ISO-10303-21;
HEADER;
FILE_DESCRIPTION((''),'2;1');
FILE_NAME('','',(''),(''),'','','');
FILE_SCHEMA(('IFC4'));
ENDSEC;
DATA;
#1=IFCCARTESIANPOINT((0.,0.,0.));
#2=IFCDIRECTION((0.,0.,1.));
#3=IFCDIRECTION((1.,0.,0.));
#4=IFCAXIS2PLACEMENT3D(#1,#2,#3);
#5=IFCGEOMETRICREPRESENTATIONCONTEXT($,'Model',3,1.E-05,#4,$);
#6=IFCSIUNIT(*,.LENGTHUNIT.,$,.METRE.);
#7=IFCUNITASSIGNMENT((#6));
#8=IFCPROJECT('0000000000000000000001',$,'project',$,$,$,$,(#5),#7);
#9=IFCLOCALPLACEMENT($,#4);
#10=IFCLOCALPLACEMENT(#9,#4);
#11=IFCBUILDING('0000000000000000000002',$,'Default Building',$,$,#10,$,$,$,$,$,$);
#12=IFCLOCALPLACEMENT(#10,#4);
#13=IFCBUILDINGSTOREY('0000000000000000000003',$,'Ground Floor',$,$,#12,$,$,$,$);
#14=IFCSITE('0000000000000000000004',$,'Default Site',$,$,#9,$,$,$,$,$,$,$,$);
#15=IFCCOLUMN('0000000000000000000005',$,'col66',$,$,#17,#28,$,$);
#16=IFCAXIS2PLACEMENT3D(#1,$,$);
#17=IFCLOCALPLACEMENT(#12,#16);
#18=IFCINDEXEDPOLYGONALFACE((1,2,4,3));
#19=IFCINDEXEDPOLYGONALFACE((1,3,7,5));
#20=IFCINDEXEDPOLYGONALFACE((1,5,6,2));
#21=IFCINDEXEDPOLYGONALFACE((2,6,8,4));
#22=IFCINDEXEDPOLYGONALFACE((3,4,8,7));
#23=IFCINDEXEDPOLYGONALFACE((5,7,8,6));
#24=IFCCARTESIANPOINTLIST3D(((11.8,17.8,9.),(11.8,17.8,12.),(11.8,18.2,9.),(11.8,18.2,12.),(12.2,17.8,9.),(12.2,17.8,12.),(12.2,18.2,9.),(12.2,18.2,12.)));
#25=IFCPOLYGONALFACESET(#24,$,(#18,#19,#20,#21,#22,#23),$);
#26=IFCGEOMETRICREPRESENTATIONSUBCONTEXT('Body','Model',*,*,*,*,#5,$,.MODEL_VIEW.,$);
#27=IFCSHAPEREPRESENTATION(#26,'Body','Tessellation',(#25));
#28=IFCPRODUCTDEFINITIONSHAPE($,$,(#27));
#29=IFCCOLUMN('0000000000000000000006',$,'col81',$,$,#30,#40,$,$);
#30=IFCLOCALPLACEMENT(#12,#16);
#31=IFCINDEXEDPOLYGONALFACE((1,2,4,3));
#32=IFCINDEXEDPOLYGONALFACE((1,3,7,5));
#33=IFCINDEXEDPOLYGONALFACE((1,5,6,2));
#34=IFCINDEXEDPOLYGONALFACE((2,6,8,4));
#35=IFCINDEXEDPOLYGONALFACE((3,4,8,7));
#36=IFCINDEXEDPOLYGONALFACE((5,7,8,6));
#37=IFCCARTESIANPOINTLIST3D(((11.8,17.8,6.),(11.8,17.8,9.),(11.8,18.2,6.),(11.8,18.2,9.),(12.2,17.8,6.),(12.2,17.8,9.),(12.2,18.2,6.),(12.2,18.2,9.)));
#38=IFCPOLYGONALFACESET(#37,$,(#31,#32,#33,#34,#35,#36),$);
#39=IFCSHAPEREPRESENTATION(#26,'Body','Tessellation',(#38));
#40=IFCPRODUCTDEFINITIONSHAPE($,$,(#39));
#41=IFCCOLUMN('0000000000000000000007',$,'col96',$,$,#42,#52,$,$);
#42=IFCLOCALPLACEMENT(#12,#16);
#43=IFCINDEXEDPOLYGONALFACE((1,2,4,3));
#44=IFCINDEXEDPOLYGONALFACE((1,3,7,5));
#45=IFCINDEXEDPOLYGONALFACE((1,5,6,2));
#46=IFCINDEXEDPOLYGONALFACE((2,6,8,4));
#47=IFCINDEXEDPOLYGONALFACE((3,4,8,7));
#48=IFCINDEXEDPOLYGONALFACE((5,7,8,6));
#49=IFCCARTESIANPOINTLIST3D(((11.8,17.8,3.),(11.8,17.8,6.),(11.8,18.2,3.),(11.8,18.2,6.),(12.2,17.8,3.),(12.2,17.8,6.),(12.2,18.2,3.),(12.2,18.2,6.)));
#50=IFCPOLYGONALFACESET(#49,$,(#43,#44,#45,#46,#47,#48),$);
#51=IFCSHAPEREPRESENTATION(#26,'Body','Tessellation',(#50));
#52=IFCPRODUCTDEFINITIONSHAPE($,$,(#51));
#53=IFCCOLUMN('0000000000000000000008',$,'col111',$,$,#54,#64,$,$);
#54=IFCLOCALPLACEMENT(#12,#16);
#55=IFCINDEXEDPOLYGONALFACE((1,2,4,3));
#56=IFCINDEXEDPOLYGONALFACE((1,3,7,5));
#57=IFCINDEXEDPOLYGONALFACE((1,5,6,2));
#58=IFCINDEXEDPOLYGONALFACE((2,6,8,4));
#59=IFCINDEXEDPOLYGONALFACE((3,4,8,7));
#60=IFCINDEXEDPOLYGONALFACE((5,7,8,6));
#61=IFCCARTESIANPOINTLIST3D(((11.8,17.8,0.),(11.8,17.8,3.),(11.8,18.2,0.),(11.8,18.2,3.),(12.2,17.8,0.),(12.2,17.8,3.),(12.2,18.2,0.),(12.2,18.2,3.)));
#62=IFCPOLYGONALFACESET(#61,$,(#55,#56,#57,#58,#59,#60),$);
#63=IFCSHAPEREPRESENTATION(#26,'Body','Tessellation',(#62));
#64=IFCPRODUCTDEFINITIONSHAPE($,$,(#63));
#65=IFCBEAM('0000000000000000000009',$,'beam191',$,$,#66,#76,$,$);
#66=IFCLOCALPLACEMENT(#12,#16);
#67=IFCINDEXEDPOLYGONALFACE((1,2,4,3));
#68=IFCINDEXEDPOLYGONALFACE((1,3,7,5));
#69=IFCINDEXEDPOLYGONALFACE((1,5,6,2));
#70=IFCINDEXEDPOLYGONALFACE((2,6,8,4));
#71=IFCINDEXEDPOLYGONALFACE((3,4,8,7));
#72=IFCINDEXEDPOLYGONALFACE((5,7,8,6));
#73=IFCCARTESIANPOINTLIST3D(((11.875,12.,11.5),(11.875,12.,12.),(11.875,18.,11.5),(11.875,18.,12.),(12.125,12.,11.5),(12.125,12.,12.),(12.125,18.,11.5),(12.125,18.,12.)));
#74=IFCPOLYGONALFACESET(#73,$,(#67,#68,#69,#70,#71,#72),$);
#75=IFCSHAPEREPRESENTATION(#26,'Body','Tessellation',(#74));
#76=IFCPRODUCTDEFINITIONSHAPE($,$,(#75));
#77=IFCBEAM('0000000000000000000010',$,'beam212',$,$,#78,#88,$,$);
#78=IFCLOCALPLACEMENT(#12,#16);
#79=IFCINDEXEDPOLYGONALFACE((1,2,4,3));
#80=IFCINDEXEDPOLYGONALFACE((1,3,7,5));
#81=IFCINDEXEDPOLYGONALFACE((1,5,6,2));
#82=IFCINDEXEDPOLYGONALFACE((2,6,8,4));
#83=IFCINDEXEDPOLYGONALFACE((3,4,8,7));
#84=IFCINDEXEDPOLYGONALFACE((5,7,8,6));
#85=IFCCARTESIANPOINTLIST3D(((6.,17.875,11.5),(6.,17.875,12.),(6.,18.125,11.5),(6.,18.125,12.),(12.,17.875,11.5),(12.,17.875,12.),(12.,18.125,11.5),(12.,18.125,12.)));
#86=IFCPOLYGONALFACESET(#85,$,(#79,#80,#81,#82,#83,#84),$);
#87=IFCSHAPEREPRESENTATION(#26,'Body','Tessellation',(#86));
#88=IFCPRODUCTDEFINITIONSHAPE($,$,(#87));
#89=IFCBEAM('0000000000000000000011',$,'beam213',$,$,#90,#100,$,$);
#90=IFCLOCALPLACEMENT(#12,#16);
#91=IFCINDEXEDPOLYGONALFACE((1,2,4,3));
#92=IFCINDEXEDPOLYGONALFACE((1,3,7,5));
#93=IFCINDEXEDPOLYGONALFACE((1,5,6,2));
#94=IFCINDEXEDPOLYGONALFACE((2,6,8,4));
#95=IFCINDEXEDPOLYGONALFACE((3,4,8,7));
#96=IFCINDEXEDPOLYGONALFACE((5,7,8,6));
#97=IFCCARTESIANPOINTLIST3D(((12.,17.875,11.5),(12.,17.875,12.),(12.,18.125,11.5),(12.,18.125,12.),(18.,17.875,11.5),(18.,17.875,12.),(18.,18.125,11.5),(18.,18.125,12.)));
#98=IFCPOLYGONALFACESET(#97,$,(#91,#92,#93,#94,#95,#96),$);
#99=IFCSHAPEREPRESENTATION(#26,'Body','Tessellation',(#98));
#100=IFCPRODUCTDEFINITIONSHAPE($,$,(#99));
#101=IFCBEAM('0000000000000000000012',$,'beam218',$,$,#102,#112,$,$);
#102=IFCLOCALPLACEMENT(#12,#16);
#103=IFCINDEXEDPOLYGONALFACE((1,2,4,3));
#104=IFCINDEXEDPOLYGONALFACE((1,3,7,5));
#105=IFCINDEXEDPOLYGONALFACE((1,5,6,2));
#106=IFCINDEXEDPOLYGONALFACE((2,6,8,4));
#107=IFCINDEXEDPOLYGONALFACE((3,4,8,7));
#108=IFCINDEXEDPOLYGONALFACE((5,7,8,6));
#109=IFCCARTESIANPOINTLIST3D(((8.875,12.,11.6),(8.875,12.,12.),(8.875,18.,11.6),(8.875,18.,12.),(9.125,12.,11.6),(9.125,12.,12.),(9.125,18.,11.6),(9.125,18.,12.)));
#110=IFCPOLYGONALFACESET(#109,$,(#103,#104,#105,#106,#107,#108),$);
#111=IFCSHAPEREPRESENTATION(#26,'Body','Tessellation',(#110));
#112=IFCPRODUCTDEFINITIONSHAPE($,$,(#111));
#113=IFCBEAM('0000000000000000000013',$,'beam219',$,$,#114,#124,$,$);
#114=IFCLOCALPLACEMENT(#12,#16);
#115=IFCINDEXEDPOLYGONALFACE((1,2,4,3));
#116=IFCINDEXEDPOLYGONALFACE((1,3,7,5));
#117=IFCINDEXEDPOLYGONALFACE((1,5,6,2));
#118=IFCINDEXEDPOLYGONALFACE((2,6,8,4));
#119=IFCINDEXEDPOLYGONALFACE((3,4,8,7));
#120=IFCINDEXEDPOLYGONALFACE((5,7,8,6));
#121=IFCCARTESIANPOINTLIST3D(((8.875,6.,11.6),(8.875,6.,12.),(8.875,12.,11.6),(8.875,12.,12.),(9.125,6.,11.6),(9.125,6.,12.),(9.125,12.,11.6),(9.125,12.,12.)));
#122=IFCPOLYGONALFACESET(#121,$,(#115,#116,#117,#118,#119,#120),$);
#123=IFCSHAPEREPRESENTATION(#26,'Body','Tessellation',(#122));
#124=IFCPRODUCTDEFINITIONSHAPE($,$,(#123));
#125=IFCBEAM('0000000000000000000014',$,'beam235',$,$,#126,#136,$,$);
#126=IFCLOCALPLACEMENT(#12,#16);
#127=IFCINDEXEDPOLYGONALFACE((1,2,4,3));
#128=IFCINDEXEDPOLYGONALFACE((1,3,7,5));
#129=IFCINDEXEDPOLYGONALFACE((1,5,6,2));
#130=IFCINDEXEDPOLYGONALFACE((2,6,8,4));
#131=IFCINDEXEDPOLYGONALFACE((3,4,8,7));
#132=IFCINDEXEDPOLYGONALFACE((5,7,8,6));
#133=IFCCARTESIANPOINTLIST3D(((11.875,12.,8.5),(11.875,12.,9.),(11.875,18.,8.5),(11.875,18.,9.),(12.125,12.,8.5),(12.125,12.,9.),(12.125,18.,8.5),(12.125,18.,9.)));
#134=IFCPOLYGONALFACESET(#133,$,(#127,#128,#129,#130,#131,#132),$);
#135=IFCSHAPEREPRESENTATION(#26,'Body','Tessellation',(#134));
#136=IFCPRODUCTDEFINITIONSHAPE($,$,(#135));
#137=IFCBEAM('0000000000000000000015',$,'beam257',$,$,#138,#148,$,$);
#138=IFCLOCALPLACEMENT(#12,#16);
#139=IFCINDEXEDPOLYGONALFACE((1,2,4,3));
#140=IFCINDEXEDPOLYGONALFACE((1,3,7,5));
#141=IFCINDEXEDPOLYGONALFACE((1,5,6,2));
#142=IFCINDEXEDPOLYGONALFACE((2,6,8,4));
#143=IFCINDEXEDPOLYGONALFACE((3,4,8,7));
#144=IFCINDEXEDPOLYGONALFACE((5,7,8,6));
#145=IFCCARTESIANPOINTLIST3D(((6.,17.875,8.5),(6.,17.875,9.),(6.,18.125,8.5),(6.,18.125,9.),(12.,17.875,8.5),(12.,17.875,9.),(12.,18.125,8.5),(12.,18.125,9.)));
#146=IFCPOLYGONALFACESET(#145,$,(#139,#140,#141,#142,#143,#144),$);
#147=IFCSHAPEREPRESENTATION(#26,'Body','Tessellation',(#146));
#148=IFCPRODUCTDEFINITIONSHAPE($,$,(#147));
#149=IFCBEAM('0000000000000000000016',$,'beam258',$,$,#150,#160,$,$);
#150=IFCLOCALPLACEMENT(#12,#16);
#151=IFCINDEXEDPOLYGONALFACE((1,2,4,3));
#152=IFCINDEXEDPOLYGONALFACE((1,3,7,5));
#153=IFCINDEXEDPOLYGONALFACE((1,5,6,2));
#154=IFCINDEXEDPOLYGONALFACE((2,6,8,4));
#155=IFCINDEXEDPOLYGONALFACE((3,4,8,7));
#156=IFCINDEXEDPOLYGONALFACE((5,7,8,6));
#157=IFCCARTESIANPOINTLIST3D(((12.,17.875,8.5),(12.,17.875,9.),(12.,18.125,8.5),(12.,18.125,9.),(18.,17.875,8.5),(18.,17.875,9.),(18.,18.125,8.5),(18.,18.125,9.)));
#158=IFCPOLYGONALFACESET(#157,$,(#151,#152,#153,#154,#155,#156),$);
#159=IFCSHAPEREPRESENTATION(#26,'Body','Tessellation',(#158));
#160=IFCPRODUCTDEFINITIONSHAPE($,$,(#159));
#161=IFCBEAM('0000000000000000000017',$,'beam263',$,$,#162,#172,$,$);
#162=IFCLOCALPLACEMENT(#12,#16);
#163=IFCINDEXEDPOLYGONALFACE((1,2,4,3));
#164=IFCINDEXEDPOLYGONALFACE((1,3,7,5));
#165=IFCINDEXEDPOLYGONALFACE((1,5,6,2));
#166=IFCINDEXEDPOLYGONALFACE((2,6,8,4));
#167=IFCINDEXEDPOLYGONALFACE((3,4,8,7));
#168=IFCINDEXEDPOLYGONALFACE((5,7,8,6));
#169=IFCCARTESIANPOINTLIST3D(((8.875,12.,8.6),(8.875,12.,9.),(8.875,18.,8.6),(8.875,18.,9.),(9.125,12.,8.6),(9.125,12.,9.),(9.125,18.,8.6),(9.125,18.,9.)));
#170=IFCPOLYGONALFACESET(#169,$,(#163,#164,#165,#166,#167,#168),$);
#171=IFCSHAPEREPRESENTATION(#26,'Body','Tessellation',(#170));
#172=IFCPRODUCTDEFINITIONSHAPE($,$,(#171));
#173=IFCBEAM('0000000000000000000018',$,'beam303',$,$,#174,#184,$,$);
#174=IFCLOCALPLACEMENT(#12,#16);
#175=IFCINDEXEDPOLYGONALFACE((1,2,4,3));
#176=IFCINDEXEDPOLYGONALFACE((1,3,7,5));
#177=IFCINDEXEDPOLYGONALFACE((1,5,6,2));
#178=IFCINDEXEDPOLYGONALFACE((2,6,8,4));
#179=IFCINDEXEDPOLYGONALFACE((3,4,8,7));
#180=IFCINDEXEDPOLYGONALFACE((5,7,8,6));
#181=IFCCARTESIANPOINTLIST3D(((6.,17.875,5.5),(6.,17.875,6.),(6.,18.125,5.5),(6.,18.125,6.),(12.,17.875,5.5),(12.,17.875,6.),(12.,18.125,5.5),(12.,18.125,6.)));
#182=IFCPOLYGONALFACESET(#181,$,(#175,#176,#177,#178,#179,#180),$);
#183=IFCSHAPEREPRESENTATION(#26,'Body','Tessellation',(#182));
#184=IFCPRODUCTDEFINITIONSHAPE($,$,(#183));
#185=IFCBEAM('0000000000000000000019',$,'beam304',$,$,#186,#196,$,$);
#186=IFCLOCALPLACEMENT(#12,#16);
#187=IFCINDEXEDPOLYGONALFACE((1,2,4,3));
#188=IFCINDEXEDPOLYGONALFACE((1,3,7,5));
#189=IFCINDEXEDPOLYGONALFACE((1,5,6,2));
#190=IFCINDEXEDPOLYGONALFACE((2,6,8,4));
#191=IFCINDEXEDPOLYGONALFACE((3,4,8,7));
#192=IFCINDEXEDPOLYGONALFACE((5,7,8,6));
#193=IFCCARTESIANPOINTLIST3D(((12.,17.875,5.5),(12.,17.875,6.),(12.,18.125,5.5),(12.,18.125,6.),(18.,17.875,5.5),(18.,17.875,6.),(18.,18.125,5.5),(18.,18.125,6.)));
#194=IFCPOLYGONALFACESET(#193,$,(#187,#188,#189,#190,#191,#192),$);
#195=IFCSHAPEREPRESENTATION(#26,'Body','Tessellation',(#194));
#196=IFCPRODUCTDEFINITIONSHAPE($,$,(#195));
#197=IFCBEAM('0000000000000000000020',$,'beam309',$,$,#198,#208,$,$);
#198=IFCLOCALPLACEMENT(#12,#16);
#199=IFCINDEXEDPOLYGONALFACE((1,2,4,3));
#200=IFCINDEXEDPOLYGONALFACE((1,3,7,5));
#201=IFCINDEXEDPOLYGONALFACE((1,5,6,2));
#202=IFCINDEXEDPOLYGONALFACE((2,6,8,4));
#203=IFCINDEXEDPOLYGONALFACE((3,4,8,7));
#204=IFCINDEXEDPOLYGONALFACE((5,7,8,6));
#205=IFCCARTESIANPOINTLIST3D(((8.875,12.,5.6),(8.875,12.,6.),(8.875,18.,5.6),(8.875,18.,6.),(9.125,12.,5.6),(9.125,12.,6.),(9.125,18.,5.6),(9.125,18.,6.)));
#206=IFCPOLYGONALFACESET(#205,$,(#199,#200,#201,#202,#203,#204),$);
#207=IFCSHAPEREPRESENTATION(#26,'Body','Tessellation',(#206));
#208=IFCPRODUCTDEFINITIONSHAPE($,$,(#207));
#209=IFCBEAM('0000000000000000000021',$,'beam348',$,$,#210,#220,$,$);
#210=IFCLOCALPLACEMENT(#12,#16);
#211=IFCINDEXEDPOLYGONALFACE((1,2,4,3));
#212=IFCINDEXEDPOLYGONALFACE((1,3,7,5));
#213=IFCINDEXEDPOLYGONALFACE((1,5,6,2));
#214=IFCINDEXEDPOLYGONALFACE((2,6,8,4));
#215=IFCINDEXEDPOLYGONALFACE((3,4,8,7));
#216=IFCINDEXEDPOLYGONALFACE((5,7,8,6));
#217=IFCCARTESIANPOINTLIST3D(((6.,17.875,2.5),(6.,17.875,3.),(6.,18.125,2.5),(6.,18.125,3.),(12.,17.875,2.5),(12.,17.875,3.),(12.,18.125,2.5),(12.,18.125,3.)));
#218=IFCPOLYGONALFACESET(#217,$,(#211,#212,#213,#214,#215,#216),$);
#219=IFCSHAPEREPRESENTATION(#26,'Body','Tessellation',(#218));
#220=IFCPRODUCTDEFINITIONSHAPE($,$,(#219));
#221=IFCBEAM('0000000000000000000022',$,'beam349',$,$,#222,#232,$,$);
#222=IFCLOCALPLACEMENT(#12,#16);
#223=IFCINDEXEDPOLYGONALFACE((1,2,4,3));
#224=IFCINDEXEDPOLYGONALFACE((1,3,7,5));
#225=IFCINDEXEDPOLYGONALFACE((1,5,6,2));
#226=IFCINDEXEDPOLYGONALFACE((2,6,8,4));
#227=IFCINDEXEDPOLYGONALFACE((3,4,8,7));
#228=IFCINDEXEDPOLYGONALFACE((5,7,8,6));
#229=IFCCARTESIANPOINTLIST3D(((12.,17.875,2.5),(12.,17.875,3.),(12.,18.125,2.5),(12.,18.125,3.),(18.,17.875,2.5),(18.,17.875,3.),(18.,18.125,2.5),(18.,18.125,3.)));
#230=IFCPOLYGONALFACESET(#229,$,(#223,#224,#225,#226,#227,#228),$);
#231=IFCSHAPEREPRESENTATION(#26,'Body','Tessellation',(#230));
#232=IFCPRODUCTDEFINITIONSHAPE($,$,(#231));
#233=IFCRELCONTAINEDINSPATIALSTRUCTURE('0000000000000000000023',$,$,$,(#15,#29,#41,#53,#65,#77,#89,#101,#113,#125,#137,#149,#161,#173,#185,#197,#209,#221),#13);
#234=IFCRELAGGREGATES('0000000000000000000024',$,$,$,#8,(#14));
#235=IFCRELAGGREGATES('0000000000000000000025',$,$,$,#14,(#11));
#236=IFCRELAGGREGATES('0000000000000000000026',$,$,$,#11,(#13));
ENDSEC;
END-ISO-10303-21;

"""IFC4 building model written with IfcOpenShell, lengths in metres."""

from ifc_helpers import new_model, si_unit, frame, origin_with_axes, place, context, subcontext, project, spatial, indexed_curve, outline, extrude, element, save


model = new_model("IFC4")

# Units and contexts
model_context = context("Model", 3, precision=1e-05, world=origin_with_axes())
body_context = subcontext(model_context, "Body", "Model", "MODEL_VIEW")
ifc_project = project(units=[si_unit("LENGTHUNIT", "METRE")], contexts=[model_context])

# Site, building, storey
site_placement = place(None, origin_with_axes())
site = spatial("IfcSite", under=ifc_project, at=site_placement, Name="Default Site")
building_placement = place(site_placement, origin_with_axes())
building = spatial("IfcBuilding", under=site, at=building_placement, Name="Default Building")
storey_placement = place(building_placement, origin_with_axes())
storey = spatial("IfcBuildingStorey", under=building, at=storey_placement, Name="Ground Floor")

# Columns
for number, where, z_axis, x_axis, name in (
    (1, (11.8, 17.8, 9.0), (0.0, 0.0, 1.0), (1.0, 0.0, 0.0), "col66"),
    (2, (11.8, 17.8, 6.0), (0.0, 0.0, 1.0), (1.0, 0.0, 0.0), "col81"),
    (3, (11.8, 17.8, 3.0), (0.0, 0.0, 1.0), (1.0, 0.0, 0.0), "col96"),
    (4, (11.8, 17.8, 0.0), (0.0, 0.0, 1.0), (1.0, 0.0, 0.0), "col111"),
):
    element("IfcColumn", number, at=place(storey_placement, frame(where, z_axis=z_axis, x_axis=x_axis)), inside=storey, Name=name, context=body_context, shape_type="SweptSolid", body=[
        extrude(outline(indexed_curve([(0.0, 0.0), (0.0, 0.4), (0.4, 0.4), (0.4, 0.0), (0.0, 0.0)], self_intersect=False)), origin_with_axes(), (0.0, 0.0, 1.0), 3.0),
    ])

# Beams
for number, where, z_axis, x_axis, name in (
    (5, (12.125, 12.0, 11.5), (0.0, 0.0, 1.0), (0.0, 1.0, 0.0), "beam191"),
    (6, (6.0, 17.875, 11.5), (0.0, 0.0, 1.0), (1.0, 0.0, 0.0), "beam212"),
    (7, (12.0, 17.875, 11.5), (0.0, 0.0, 1.0), (1.0, 0.0, 0.0), "beam213"),
):
    element("IfcBeam", number, at=place(storey_placement, frame(where, z_axis=z_axis, x_axis=x_axis)), inside=storey, Name=name, context=body_context, shape_type="SweptSolid", body=[
        extrude(outline(indexed_curve([(0.0, 0.0), (0.0, 0.25), (6.0, 0.25), (6.0, 0.0), (0.0, 0.0)], self_intersect=False)), origin_with_axes(), (0.0, 0.0, 1.0), 0.5),
    ])
for number, where, z_axis, x_axis, name in (
    (8, (8.875, 18.0, 11.6), (0.0, 0.0, 1.0), (0.0, -1.0, 0.0), "beam218"),
    (9, (8.875, 12.0, 11.6), (0.0, 0.0, 1.0), (0.0, -1.0, 0.0), "beam219"),
):
    element("IfcBeam", number, at=place(storey_placement, frame(where, z_axis=z_axis, x_axis=x_axis)), inside=storey, Name=name, context=body_context, shape_type="SweptSolid", body=[
        extrude(outline(indexed_curve([(0.0, 0.0), (0.0, 0.25), (6.0, 0.25), (6.0, 0.0), (0.0, 0.0)], self_intersect=False)), origin_with_axes(), (0.0, 0.0, 1.0), 0.4),
    ])
for number, where, z_axis, x_axis, name in (
    (10, (12.125, 12.0, 8.5), (0.0, 0.0, 1.0), (0.0, 1.0, 0.0), "beam235"),
    (11, (6.0, 17.875, 8.5), (0.0, 0.0, 1.0), (1.0, 0.0, 0.0), "beam257"),
    (12, (12.0, 17.875, 8.5), (0.0, 0.0, 1.0), (1.0, 0.0, 0.0), "beam258"),
):
    element("IfcBeam", number, at=place(storey_placement, frame(where, z_axis=z_axis, x_axis=x_axis)), inside=storey, Name=name, context=body_context, shape_type="SweptSolid", body=[
        extrude(outline(indexed_curve([(0.0, 0.0), (0.0, 0.25), (6.0, 0.25), (6.0, 0.0), (0.0, 0.0)], self_intersect=False)), origin_with_axes(), (0.0, 0.0, 1.0), 0.5),
    ])
beam_1_placement = place(storey_placement, frame((8.875, 18.0, 8.6), z_axis=(0.0, 0.0, 1.0), x_axis=(0.0, -1.0, 0.0)))
element("IfcBeam", 13, at=beam_1_placement, inside=storey, Name="beam263", context=body_context, shape_type="SweptSolid", body=[
    extrude(outline(indexed_curve([(0.0, 0.0), (0.0, 0.25), (6.0, 0.25), (6.0, 0.0), (0.0, 0.0)], self_intersect=False)), origin_with_axes(), (0.0, 0.0, 1.0), 0.4),
])
for number, where, z_axis, x_axis, name in (
    (14, (6.0, 17.875, 5.5), (0.0, 0.0, 1.0), (1.0, 0.0, 0.0), "beam303"),
    (15, (12.0, 17.875, 5.5), (0.0, 0.0, 1.0), (1.0, 0.0, 0.0), "beam304"),
):
    element("IfcBeam", number, at=place(storey_placement, frame(where, z_axis=z_axis, x_axis=x_axis)), inside=storey, Name=name, context=body_context, shape_type="SweptSolid", body=[
        extrude(outline(indexed_curve([(0.0, 0.0), (0.0, 0.25), (6.0, 0.25), (6.0, 0.0), (0.0, 0.0)], self_intersect=False)), origin_with_axes(), (0.0, 0.0, 1.0), 0.5),
    ])
beam_2_placement = place(storey_placement, frame((8.875, 18.0, 5.6), z_axis=(0.0, 0.0, 1.0), x_axis=(0.0, -1.0, 0.0)))
element("IfcBeam", 16, at=beam_2_placement, inside=storey, Name="beam309", context=body_context, shape_type="SweptSolid", body=[
    extrude(outline(indexed_curve([(0.0, 0.0), (0.0, 0.25), (6.0, 0.25), (6.0, 0.0), (0.0, 0.0)], self_intersect=False)), origin_with_axes(), (0.0, 0.0, 1.0), 0.4),
])
for number, where, z_axis, x_axis, name in (
    (17, (6.0, 17.875, 2.5), (0.0, 0.0, 1.0), (1.0, 0.0, 0.0), "beam348"),
    (18, (12.0, 17.875, 2.5), (0.0, 0.0, 1.0), (1.0, 0.0, 0.0), "beam349"),
):
    element("IfcBeam", number, at=place(storey_placement, frame(where, z_axis=z_axis, x_axis=x_axis)), inside=storey, Name=name, context=body_context, shape_type="SweptSolid", body=[
        extrude(outline(indexed_curve([(0.0, 0.0), (0.0, 0.25), (6.0, 0.25), (6.0, 0.0), (0.0, 0.0)], self_intersect=False)), origin_with_axes(), (0.0, 0.0, 1.0), 0.5),
    ])

save(model, "model.ifc")
